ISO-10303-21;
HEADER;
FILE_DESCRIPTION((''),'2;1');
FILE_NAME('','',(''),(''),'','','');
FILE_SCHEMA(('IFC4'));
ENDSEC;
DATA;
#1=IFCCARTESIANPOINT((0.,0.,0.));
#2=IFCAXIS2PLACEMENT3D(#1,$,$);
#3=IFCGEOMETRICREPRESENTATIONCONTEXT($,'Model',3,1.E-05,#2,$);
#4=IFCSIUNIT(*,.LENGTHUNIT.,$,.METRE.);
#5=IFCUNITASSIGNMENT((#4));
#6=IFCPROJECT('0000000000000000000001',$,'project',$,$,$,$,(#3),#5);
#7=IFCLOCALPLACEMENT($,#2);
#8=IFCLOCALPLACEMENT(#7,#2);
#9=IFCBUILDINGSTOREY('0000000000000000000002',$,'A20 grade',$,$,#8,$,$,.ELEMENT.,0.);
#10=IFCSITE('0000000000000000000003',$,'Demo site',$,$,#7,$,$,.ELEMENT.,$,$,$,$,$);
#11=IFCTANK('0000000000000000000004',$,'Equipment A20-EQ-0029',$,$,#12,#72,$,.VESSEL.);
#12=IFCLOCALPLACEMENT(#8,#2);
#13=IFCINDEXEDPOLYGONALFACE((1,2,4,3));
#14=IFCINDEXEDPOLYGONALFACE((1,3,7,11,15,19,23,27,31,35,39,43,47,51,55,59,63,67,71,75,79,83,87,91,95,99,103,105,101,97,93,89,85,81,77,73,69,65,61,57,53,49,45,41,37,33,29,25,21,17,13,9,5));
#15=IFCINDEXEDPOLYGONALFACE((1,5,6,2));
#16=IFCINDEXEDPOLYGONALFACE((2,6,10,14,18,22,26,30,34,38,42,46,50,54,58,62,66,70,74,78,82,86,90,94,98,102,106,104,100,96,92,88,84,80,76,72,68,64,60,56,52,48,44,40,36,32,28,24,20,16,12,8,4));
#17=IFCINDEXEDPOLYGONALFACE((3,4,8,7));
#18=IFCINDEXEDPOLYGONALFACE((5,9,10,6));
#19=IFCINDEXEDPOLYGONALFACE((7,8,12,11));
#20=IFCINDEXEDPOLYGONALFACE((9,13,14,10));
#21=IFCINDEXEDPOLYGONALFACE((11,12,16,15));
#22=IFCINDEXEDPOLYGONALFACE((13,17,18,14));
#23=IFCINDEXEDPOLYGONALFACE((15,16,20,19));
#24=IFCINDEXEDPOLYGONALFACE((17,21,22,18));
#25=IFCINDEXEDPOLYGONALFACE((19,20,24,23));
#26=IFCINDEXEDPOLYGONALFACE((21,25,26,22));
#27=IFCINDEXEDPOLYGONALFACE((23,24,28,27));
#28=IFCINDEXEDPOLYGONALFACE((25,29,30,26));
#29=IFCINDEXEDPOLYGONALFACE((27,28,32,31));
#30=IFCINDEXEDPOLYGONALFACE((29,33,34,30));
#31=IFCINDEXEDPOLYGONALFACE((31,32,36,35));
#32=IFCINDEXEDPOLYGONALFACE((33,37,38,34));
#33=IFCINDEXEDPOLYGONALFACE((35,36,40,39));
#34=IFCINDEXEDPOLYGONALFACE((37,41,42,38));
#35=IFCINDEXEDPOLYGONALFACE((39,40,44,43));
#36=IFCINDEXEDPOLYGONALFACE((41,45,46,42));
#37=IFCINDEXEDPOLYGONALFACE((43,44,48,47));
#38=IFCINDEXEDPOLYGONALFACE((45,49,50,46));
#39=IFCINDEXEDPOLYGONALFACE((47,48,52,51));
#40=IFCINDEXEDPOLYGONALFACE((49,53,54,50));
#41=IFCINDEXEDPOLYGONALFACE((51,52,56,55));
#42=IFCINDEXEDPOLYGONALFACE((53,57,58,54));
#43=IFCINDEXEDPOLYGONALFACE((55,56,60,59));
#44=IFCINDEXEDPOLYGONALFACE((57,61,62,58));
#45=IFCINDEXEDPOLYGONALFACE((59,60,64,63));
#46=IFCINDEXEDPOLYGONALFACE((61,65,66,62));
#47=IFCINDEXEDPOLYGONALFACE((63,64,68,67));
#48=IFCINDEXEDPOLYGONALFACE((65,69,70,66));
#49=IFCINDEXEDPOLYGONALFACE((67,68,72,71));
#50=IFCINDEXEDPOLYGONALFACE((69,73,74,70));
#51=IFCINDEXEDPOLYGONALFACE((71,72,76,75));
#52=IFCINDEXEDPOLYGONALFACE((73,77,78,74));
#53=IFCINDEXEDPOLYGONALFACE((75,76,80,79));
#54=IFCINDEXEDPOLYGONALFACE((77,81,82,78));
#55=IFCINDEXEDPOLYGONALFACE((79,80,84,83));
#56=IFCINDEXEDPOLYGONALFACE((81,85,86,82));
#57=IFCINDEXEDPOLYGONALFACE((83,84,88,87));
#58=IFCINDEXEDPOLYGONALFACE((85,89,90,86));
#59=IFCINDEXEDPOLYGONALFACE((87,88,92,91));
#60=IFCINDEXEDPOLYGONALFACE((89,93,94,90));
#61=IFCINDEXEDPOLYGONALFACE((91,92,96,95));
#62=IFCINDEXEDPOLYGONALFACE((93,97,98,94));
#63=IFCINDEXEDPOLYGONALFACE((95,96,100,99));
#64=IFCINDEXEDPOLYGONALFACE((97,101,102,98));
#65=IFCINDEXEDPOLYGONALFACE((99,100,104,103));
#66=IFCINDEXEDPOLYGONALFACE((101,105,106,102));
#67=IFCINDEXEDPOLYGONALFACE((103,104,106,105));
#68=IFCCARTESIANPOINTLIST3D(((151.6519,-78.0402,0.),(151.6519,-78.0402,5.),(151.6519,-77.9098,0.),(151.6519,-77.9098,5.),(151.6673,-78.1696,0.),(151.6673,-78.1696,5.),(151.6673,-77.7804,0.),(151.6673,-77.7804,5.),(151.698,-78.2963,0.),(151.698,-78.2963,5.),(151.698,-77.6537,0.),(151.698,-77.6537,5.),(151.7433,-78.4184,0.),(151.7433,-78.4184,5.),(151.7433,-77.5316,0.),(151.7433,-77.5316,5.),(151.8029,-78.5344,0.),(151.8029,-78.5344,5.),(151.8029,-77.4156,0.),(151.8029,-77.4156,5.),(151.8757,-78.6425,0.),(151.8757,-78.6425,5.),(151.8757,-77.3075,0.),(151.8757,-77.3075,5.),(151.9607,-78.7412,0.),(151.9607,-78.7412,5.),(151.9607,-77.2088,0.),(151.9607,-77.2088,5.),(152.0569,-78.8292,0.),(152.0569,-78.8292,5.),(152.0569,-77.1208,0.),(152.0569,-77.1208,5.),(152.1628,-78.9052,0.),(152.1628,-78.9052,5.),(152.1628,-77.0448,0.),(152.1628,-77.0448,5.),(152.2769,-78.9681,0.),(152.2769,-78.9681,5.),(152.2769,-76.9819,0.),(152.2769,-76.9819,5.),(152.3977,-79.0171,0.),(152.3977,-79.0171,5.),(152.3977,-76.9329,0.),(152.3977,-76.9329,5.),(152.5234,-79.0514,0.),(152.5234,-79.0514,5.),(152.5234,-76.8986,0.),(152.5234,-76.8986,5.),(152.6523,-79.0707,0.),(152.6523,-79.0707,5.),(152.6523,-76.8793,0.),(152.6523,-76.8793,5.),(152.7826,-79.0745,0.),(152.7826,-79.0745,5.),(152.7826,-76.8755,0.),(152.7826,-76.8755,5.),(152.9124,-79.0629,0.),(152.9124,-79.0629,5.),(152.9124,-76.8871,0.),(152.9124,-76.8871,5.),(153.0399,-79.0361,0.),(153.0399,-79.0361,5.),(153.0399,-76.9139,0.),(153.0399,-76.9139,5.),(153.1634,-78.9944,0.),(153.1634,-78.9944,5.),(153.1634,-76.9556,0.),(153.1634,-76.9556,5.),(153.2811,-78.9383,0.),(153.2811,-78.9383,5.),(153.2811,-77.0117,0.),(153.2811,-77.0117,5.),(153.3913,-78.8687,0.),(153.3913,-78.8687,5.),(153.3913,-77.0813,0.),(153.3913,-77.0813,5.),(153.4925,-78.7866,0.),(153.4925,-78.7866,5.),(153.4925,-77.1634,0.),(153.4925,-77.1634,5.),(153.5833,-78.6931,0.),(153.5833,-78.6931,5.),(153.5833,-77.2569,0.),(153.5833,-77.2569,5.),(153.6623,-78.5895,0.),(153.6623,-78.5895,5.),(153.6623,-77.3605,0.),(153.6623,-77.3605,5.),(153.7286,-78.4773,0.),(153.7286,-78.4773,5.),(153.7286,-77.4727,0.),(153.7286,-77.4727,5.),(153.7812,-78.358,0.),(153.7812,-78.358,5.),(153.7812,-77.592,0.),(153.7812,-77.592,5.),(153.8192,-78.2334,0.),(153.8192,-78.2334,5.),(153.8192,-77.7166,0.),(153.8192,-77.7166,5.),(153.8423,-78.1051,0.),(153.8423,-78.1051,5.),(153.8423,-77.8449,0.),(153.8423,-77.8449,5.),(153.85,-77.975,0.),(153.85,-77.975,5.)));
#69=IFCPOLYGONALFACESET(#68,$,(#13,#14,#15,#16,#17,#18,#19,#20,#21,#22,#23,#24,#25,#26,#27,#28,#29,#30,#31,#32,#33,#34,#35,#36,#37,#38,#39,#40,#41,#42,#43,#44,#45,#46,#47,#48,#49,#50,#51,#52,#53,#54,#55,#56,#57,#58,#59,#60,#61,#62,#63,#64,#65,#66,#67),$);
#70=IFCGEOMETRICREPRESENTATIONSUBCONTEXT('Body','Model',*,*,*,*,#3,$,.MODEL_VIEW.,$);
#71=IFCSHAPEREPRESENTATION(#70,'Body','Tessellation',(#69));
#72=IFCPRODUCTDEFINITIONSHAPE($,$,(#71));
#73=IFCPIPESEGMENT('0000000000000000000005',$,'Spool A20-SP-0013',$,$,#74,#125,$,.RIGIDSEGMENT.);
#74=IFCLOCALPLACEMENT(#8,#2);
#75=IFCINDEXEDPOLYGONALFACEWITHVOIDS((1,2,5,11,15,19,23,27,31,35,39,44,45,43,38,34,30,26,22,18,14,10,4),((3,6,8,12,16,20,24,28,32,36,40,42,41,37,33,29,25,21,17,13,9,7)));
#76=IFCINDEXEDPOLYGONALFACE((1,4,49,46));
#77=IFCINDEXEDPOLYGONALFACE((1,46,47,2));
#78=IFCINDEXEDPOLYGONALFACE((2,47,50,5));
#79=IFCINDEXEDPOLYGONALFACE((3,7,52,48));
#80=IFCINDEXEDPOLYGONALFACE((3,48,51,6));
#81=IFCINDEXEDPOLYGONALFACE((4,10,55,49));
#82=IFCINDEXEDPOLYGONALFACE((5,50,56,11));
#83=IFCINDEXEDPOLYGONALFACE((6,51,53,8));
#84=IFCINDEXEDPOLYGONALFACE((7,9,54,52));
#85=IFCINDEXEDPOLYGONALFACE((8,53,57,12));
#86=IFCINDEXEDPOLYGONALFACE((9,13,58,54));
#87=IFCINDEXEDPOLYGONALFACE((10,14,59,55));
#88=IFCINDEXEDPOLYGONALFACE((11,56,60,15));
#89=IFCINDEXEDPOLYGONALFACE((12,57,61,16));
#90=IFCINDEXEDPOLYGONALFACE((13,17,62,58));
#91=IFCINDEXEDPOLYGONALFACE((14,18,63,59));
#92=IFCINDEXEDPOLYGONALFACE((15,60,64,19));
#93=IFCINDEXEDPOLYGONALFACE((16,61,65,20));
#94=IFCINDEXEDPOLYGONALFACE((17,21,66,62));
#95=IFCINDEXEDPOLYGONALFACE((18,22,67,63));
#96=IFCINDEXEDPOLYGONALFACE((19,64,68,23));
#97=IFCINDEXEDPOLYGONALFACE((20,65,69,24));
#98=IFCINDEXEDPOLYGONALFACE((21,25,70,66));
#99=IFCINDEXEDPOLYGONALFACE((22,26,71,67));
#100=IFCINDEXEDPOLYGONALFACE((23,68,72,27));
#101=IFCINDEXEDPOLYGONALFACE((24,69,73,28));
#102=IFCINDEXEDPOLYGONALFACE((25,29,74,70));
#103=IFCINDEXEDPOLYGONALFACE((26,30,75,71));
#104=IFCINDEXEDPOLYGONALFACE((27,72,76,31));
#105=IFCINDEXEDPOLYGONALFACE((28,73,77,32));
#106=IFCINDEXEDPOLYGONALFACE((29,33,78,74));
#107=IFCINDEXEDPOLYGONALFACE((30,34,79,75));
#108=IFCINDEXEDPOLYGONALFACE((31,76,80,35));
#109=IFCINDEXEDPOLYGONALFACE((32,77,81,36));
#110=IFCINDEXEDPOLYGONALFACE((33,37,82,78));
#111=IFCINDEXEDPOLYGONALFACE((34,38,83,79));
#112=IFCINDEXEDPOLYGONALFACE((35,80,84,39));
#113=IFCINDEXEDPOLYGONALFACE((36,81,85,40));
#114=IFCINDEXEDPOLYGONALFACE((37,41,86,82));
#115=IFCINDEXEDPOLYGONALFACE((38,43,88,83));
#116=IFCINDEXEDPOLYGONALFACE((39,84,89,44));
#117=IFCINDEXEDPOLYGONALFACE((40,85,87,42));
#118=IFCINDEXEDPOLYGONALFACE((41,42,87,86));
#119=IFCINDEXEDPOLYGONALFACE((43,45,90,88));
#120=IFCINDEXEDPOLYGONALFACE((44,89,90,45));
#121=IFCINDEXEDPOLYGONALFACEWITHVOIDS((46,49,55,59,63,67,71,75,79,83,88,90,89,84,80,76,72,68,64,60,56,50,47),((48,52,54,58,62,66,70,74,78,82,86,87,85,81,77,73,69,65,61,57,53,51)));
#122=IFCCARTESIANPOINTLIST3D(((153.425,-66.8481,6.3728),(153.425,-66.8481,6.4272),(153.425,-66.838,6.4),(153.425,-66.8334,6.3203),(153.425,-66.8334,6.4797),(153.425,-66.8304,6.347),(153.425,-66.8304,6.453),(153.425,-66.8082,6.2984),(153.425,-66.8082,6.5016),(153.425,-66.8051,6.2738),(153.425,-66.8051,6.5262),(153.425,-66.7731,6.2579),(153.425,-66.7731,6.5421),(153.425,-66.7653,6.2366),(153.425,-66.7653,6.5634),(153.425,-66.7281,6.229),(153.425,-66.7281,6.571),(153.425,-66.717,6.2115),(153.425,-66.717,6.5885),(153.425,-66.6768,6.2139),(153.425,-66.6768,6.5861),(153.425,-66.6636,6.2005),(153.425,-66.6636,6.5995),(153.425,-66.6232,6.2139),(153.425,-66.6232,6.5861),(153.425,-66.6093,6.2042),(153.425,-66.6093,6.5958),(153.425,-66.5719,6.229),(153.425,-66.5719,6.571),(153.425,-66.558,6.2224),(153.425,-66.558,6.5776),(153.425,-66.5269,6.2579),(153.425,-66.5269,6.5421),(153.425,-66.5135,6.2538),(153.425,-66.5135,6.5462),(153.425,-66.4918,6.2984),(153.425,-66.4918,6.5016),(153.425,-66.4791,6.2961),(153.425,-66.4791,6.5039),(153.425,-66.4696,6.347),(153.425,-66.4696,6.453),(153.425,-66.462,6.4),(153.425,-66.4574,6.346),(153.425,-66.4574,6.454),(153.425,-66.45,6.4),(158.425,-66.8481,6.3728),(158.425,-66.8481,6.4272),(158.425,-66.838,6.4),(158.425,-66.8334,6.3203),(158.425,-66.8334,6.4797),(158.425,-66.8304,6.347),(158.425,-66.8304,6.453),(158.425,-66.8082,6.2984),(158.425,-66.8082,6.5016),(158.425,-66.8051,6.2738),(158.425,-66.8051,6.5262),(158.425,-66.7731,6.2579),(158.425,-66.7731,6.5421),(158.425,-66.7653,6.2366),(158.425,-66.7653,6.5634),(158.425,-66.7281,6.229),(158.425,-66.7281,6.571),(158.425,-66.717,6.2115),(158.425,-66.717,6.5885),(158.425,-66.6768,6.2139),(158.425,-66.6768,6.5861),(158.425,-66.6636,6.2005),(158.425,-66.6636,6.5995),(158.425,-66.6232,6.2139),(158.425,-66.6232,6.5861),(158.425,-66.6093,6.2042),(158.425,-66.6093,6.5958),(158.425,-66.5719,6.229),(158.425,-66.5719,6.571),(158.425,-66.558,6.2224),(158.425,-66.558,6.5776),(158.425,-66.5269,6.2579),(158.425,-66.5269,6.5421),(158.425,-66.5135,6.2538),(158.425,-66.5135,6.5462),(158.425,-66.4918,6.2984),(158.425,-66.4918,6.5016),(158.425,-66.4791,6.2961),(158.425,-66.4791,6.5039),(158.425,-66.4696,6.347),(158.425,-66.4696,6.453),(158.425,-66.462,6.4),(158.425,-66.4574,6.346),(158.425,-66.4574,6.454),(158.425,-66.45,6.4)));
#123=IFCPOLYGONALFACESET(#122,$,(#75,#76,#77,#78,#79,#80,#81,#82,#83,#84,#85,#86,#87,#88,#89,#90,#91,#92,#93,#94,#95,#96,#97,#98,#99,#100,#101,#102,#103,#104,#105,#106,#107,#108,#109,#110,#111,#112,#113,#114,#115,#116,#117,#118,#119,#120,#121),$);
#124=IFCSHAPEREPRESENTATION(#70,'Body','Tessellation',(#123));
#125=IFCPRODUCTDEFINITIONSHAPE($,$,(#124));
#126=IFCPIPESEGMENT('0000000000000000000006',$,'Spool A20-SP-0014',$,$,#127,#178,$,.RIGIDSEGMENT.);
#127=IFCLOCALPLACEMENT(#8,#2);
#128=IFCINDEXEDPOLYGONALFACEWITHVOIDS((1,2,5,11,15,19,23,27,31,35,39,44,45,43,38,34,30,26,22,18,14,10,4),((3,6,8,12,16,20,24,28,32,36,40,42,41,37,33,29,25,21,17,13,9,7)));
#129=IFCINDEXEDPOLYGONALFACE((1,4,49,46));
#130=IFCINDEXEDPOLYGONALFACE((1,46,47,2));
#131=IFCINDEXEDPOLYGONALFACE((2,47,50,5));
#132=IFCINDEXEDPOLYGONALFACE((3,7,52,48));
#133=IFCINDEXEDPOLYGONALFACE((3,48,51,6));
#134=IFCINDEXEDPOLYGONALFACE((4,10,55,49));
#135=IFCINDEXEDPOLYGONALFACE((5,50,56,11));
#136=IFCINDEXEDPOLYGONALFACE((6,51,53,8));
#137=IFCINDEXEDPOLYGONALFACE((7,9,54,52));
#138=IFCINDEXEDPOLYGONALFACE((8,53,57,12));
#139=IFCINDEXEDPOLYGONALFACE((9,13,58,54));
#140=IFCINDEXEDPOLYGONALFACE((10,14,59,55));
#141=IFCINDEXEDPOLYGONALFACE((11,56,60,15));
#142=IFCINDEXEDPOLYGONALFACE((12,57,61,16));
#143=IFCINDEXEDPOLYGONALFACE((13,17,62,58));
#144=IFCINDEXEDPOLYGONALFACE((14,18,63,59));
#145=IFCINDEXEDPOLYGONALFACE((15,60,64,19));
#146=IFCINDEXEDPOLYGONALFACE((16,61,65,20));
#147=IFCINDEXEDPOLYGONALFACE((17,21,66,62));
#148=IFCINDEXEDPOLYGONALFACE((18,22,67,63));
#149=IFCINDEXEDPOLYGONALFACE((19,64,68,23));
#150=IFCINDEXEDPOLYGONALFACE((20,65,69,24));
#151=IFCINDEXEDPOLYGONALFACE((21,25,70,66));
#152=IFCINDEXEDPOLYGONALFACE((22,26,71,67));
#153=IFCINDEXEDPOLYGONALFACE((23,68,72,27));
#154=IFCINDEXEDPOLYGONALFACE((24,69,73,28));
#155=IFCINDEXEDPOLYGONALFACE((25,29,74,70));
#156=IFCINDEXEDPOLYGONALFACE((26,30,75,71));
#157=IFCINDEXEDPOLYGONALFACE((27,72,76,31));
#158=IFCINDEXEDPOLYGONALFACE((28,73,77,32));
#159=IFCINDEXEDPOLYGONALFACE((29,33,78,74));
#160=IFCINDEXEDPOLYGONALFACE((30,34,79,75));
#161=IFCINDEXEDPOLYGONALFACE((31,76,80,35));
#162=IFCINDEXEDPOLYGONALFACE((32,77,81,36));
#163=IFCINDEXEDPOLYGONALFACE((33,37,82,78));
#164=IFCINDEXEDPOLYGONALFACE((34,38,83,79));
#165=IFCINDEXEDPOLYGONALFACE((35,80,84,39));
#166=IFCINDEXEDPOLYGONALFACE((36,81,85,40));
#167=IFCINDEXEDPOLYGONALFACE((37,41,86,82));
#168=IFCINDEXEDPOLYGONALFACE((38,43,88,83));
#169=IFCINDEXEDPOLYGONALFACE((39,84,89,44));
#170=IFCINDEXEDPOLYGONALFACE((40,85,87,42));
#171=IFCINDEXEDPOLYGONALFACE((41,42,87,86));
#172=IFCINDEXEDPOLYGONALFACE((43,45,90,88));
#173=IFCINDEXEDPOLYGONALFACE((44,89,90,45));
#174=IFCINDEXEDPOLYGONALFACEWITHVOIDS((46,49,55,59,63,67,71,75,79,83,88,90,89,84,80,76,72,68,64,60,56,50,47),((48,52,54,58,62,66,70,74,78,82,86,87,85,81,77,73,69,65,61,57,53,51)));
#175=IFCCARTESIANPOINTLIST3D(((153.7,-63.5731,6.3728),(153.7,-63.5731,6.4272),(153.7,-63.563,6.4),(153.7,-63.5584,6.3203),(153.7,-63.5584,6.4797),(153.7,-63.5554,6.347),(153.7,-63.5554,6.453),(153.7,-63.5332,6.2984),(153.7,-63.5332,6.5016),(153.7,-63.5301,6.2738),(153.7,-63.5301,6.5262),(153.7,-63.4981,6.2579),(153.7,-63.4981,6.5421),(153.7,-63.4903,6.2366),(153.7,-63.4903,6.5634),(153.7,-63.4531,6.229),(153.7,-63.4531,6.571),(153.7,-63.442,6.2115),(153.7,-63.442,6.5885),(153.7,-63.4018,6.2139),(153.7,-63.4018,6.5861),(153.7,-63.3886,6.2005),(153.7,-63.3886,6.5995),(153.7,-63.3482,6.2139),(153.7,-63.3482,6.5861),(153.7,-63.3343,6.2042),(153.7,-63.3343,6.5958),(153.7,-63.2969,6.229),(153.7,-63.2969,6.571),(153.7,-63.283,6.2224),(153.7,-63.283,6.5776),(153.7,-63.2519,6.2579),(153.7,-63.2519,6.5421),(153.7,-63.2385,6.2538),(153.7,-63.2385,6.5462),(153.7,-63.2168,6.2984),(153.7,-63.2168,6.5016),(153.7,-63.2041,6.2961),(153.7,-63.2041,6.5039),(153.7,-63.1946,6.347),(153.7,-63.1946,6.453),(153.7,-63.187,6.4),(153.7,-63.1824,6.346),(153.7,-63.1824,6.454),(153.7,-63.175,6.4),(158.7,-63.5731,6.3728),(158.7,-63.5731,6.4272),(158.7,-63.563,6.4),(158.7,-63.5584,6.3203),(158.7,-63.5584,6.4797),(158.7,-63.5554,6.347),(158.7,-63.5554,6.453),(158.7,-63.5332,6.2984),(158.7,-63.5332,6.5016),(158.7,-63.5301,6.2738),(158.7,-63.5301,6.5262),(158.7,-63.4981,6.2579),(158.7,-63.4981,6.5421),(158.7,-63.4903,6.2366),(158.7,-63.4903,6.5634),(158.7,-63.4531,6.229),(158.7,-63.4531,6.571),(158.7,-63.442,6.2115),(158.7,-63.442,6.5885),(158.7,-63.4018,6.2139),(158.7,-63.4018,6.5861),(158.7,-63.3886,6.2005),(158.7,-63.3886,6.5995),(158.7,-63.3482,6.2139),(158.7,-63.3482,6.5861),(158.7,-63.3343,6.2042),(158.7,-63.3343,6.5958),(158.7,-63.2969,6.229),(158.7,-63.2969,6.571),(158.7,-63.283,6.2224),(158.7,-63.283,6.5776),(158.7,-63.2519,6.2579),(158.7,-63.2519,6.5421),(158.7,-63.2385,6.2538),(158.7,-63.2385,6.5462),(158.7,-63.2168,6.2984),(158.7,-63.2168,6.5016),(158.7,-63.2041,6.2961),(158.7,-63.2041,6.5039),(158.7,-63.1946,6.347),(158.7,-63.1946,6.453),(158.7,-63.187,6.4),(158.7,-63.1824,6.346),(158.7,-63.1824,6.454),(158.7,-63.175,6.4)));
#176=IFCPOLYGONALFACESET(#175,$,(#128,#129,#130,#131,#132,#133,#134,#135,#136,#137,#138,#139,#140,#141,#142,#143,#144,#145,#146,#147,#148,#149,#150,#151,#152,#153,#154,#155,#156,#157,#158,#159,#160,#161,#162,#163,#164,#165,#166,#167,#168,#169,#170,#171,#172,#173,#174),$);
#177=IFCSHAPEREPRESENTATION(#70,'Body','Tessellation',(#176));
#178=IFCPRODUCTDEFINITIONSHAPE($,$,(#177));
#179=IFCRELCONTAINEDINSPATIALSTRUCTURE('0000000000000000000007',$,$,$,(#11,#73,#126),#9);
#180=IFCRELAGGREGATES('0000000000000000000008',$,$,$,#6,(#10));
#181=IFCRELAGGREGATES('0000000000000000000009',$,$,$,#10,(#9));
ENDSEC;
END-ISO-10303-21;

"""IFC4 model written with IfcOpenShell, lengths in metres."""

from ifc_helpers import new_model, si_unit, frame, origin, place, context, subcontext, project, spatial, circle, hollow_circle, extrude, element, save


model = new_model("IFC4")

# Units and contexts
model_context = context("Model", 3, precision=1e-05, world=origin())
body_context = subcontext(model_context, "Body", "Model", "MODEL_VIEW")
ifc_project = project(units=[si_unit("LENGTHUNIT", "METRE")], contexts=[model_context])

# Site, storey
site_placement = place(None, origin())
site = spatial("IfcSite", under=ifc_project, at=site_placement, Name="Demo site", CompositionType="ELEMENT")
storey_placement = place(site_placement, origin())
storey = spatial("IfcBuildingStorey", under=site, at=storey_placement, Name="A20 grade", CompositionType="ELEMENT", Elevation=0.0)

# Tank
for number, where, name in (
    (1, (152.75, -77.975, 0.0), "Equipment A20-EQ-0029"),
):
    element("IfcTank", number, at=place(storey_placement, frame(where)), inside=storey, Name=name, PredefinedType="VESSEL", context=body_context, shape_type="SweptSolid", body=[
        extrude(circle(Radius=1.1), origin(), (0.0, 0.0, 1.0), 5.0),
    ])

# Pipe segments
for number, where, name in (
    (2, (153.425, -66.65, 6.4), "Spool A20-SP-0013"),
    (3, (153.7, -63.375, 6.4), "Spool A20-SP-0014"),
):
    element("IfcPipeSegment", number, at=place(storey_placement, frame(where)), inside=storey, Name=name, PredefinedType="RIGIDSEGMENT", context=body_context, shape_type="SweptSolid", body=[
        extrude(hollow_circle(Radius=0.2, WallThickness=0.012), frame((0.0, 0.0, 0.0), z_axis=(1.0, 0.0, 0.0), x_axis=(0.0, 1.0, 0.0)), (0.0, 0.0, 1.0), 5.0),
    ])

save(model, "model.ifc")
